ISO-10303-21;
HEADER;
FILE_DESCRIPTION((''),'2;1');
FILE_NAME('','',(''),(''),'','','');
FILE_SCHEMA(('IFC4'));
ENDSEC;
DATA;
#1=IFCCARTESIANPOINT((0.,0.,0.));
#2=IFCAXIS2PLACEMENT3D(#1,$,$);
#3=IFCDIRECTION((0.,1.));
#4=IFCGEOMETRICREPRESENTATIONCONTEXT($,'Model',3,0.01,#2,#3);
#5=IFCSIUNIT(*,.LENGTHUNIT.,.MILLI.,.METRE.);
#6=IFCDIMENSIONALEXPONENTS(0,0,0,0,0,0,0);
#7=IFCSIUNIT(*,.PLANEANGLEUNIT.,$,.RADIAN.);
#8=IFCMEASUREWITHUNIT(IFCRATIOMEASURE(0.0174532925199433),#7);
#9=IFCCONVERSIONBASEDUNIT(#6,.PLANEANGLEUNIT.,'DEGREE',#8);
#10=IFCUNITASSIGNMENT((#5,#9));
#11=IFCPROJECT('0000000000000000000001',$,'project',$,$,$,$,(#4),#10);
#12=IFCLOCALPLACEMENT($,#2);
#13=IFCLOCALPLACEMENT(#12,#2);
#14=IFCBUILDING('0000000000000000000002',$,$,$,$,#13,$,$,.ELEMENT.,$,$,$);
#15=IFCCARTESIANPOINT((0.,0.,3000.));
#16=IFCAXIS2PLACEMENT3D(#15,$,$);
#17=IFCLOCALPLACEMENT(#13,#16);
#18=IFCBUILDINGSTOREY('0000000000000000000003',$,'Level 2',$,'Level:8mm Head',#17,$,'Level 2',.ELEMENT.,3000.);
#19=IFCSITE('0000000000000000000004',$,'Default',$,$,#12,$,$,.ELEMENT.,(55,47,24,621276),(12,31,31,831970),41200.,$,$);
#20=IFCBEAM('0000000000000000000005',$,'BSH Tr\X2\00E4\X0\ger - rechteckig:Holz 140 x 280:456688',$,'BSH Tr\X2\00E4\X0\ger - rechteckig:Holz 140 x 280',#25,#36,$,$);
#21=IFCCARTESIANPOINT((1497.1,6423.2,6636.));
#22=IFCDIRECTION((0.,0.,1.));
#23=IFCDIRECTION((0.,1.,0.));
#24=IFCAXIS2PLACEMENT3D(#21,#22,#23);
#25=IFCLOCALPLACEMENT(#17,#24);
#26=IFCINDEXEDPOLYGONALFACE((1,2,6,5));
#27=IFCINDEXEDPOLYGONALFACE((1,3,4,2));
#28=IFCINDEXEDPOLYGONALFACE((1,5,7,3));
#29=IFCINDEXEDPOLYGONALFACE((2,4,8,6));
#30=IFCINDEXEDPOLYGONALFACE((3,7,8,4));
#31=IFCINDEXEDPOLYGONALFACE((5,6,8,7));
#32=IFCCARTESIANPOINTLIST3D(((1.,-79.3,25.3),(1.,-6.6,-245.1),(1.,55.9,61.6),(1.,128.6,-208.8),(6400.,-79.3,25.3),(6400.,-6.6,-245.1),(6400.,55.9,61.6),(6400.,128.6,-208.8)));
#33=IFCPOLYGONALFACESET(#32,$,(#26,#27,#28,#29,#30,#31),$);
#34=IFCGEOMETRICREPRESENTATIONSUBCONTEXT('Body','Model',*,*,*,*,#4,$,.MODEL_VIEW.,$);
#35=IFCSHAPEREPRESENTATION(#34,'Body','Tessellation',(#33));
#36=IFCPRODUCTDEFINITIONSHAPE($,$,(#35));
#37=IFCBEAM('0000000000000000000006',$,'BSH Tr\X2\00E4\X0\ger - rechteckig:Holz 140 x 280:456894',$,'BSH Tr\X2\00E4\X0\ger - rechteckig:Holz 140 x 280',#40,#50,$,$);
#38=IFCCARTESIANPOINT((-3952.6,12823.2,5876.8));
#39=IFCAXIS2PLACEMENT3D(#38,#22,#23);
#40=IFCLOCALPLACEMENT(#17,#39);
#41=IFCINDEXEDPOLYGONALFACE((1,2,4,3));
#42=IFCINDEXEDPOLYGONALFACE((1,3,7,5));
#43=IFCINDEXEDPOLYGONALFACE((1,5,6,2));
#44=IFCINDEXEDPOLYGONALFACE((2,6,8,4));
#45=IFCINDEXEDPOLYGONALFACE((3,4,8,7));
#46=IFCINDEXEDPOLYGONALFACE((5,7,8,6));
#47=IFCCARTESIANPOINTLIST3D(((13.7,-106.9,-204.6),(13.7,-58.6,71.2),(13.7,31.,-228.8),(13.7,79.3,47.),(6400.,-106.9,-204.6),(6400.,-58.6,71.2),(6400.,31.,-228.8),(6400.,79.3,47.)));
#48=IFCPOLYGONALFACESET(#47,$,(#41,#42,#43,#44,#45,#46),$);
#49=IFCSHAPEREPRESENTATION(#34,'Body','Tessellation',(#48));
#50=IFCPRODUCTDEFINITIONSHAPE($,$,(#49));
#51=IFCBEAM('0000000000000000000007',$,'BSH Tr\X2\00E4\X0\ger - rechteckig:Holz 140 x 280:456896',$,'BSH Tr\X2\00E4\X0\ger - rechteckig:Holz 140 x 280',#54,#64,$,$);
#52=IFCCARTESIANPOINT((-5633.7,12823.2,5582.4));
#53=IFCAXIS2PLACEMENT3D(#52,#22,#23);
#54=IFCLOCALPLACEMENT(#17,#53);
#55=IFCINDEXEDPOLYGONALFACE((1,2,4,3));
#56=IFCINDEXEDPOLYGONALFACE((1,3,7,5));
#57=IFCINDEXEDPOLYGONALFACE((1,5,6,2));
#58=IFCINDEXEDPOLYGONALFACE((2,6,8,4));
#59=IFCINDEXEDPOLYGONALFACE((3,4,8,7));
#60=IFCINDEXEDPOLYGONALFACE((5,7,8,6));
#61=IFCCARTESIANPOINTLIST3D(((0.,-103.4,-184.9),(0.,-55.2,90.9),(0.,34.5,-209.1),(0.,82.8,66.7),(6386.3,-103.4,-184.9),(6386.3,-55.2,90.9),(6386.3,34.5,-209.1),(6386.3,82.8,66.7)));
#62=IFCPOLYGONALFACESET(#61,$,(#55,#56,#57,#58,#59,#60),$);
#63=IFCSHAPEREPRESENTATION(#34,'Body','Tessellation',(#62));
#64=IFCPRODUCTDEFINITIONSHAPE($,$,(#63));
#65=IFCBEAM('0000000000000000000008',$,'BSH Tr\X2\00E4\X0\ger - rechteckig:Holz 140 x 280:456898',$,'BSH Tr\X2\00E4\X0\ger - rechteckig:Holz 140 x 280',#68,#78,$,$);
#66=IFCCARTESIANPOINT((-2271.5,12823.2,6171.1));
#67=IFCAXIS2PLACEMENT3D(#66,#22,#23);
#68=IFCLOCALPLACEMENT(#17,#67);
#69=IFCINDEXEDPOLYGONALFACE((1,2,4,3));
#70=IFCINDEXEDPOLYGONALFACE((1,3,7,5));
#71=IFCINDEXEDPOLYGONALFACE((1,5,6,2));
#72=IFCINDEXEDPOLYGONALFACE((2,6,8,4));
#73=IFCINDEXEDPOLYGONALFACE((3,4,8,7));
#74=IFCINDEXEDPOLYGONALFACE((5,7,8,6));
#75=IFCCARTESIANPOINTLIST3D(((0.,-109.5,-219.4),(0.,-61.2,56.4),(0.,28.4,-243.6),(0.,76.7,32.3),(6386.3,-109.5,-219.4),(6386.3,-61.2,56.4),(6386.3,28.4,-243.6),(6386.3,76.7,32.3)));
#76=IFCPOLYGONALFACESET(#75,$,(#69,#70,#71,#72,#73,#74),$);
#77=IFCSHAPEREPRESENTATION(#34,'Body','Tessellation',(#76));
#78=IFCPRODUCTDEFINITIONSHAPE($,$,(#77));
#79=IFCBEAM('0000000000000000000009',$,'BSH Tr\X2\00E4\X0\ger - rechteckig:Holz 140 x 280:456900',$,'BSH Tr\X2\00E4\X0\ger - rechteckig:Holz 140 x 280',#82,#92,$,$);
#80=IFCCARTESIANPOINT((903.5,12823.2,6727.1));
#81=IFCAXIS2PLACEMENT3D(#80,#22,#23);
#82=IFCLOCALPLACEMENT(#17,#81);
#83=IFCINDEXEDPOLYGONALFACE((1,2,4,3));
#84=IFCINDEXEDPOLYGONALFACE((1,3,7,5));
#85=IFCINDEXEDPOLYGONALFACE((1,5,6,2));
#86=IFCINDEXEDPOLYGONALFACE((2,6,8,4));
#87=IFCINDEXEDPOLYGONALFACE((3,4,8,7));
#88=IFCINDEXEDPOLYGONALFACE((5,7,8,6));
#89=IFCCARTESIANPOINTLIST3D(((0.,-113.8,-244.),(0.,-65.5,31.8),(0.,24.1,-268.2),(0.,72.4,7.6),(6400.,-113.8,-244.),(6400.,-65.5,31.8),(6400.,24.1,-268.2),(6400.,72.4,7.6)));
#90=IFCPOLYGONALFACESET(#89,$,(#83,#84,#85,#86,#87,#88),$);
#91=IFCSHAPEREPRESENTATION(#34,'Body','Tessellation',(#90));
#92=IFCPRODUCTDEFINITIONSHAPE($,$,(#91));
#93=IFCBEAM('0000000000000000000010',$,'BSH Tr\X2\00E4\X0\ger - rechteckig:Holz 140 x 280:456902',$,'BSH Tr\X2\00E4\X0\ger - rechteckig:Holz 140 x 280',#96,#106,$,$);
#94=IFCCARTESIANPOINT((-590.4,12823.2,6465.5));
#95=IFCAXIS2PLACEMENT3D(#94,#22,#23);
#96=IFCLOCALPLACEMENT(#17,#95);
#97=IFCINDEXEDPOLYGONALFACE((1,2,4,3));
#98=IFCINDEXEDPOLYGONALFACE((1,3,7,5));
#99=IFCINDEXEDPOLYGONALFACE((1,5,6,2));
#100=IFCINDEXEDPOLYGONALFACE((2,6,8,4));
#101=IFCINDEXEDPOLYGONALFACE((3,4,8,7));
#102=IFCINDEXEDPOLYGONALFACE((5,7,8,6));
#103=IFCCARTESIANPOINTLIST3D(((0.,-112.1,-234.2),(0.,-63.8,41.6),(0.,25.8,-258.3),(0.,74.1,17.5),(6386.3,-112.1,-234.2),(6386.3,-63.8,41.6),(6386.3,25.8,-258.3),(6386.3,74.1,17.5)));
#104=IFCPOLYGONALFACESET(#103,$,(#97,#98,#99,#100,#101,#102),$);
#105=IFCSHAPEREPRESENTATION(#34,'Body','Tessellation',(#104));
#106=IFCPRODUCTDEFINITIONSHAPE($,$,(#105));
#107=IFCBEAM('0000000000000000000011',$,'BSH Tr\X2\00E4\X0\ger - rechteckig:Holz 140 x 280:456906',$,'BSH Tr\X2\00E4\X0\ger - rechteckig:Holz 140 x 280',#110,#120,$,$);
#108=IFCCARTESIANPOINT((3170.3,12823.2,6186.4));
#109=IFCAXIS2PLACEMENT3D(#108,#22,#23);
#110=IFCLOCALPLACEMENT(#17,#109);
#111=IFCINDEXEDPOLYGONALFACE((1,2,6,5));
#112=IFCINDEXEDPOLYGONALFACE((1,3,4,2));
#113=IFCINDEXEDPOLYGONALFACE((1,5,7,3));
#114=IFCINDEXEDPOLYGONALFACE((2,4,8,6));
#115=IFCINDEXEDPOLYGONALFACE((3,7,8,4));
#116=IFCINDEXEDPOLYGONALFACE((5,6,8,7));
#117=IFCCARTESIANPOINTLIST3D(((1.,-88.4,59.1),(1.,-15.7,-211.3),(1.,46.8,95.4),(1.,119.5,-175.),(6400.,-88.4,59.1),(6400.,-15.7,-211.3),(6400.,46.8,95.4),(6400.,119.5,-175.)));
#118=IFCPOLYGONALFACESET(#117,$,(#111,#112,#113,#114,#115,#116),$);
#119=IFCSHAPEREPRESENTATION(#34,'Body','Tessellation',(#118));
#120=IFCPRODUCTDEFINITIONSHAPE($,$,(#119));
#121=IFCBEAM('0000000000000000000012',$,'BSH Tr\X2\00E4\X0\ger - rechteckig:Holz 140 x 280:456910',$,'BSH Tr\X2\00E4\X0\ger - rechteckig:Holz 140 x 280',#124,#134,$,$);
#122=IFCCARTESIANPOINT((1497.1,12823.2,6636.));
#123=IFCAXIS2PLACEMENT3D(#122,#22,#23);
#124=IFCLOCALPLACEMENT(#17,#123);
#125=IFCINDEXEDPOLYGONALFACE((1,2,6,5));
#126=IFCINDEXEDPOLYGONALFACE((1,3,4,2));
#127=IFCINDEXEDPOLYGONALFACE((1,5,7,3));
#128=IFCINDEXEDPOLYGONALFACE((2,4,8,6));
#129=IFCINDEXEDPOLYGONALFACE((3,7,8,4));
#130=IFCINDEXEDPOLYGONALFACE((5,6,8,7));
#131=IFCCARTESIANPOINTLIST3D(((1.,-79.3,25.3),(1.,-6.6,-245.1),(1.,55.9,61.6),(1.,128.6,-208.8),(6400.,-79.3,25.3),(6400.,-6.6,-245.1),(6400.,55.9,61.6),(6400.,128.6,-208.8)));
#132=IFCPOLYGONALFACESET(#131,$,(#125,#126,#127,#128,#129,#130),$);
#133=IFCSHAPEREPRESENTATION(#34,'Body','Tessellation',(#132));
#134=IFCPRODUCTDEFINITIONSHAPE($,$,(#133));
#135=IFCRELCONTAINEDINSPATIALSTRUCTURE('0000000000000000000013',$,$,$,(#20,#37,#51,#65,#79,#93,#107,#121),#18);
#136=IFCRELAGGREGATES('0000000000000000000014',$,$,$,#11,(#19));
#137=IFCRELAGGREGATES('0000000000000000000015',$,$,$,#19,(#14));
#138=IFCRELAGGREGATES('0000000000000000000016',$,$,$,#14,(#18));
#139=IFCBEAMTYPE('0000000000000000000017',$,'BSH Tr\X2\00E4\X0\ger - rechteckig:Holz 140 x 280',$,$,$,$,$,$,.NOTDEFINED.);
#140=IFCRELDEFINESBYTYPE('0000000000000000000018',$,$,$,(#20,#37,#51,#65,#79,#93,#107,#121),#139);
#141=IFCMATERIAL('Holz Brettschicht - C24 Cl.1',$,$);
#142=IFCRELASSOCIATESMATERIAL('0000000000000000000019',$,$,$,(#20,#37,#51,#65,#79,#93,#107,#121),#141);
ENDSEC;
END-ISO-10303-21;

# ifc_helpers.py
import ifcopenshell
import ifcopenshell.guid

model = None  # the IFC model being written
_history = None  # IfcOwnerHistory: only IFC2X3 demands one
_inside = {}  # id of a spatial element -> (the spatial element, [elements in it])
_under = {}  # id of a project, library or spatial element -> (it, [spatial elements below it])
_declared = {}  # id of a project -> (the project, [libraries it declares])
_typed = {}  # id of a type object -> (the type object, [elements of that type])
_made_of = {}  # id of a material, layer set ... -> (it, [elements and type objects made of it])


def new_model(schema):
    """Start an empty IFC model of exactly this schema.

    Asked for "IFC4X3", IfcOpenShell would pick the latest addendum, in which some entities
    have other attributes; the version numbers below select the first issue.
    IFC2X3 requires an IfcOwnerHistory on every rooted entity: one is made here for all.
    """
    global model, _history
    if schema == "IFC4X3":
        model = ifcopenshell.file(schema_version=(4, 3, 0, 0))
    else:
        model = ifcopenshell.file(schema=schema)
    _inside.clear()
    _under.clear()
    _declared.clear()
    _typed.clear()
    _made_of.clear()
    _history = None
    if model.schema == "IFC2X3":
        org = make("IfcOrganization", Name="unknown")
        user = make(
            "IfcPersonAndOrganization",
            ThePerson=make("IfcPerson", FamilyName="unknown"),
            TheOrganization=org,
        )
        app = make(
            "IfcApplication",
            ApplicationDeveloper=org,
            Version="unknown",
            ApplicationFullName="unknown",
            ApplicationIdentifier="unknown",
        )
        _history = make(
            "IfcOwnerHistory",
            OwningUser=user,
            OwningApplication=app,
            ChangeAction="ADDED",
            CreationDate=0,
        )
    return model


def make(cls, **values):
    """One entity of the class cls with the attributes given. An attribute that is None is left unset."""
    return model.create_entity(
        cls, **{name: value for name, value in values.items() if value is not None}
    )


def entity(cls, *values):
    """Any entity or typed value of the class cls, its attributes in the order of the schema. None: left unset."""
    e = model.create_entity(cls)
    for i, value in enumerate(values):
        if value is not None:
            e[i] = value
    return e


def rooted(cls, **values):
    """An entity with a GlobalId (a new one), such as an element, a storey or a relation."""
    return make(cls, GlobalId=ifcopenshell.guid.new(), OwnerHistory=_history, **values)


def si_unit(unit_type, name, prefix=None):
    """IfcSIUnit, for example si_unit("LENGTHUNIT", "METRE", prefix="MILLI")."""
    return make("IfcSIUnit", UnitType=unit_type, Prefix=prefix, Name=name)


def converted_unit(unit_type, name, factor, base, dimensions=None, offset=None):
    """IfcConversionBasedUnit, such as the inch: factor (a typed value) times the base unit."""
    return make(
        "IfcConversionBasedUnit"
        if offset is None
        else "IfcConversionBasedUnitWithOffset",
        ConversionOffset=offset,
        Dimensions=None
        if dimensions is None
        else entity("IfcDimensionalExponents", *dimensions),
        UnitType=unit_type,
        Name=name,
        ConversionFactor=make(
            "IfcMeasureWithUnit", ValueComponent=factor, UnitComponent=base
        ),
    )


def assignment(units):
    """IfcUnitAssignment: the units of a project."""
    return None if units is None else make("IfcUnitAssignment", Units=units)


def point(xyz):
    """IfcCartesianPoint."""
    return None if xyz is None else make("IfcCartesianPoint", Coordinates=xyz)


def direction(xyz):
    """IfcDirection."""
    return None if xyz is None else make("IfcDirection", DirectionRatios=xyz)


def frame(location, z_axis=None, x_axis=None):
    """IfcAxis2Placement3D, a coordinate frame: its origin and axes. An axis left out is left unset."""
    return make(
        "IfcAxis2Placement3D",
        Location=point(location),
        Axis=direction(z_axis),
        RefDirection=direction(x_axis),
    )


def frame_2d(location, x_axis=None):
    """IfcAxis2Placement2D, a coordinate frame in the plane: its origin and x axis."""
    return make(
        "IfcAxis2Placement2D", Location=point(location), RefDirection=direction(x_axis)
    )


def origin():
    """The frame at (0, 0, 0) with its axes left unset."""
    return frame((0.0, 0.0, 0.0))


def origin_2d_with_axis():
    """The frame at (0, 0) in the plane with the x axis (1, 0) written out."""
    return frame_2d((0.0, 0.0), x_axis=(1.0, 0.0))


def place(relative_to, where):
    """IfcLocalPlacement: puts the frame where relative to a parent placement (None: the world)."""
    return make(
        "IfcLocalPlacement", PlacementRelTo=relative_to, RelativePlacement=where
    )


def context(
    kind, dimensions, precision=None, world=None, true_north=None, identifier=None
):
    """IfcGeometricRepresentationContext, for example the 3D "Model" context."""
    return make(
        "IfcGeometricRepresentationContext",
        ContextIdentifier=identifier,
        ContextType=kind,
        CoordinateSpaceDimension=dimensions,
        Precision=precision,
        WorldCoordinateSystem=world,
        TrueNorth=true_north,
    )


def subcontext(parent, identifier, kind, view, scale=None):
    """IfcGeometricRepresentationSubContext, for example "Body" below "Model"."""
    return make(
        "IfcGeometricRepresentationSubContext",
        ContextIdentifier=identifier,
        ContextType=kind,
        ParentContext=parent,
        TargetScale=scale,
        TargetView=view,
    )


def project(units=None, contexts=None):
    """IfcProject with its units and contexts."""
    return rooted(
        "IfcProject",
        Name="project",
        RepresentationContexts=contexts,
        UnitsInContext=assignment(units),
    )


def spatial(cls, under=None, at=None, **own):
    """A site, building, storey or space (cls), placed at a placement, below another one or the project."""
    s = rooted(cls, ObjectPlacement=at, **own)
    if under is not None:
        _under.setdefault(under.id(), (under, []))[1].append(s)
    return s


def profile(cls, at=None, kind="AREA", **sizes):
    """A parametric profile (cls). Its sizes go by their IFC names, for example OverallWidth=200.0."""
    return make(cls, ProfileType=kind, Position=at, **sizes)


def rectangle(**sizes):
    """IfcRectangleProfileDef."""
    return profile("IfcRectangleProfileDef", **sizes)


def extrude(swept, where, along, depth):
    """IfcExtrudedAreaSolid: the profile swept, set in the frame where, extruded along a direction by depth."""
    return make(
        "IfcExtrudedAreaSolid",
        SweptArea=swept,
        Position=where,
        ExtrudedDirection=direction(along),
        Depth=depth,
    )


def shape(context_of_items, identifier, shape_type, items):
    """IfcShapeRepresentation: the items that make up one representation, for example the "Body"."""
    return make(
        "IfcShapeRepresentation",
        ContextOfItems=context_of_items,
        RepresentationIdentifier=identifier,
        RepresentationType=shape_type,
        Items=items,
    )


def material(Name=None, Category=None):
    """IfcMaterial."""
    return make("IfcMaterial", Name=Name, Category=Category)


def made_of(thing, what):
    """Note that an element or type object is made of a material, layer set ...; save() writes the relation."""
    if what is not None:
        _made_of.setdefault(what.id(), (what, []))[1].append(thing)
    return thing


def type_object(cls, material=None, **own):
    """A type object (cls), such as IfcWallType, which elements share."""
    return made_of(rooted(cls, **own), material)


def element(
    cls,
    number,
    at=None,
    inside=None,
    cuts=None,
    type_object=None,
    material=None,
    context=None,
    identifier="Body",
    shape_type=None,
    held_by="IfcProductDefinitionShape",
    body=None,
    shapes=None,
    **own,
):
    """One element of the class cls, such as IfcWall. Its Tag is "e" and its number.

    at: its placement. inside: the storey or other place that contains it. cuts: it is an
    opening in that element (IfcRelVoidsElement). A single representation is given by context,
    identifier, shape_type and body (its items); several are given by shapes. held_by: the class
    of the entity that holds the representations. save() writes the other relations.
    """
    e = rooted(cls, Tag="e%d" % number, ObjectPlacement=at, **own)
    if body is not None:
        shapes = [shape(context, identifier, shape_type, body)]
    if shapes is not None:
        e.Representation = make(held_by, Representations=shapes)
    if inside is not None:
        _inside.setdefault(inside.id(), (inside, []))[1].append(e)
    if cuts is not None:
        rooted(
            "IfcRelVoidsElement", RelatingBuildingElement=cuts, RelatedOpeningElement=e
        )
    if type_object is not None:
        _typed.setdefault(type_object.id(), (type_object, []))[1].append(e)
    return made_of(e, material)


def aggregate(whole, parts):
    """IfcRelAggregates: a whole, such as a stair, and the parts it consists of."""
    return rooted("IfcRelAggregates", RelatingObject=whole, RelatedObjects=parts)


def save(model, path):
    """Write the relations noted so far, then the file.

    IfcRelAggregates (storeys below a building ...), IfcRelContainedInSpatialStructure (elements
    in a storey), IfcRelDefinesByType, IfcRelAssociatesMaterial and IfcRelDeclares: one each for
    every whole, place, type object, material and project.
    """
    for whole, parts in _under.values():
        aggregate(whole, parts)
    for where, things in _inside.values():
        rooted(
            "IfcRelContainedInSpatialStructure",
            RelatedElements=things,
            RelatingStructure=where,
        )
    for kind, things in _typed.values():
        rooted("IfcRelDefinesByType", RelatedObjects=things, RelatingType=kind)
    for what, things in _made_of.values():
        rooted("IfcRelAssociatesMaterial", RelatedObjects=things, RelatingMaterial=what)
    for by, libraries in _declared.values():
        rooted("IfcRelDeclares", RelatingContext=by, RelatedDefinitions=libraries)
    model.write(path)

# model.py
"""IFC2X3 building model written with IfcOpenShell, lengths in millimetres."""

from ifc_helpers import new_model, entity, si_unit, converted_unit, direction, frame, frame_2d, origin, origin_2d_with_axis, place, context, subcontext, project, spatial, rectangle, extrude, material, type_object, element, save


model = new_model("IFC2X3")

# Units and contexts
model_context = context("Model", 3, precision=0.01, world=origin(), true_north=direction((0.0, 1.0)))
body_context = subcontext(model_context, "Body", "Model", "MODEL_VIEW")
ifc_project = project(units=[si_unit("LENGTHUNIT", "METRE", prefix="MILLI"), converted_unit("PLANEANGLEUNIT", "DEGREE", entity("IfcRatioMeasure", 0.0174532925199433), si_unit("PLANEANGLEUNIT", "RADIAN"), dimensions=[0, 0, 0, 0, 0, 0, 0])], contexts=[model_context])

# Site, building, storey
site_placement = place(None, origin())
site = spatial("IfcSite", under=ifc_project, at=site_placement, Name="Default", CompositionType="ELEMENT", RefLatitude=(55, 47, 24, 621276), RefLongitude=(12, 31, 31, 831970), RefElevation=41200.0)
building_placement = place(site_placement, origin())
building = spatial("IfcBuilding", under=site, at=building_placement, CompositionType="ELEMENT")
storey_placement = place(building_placement, frame((0.0, 0.0, 3000.0)))
storey = spatial("IfcBuildingStorey", under=building, at=storey_placement, Name="Level 2", ObjectType="Level:8mm Head", LongName="Level 2", CompositionType="ELEMENT", Elevation=3000.0)

# Shared definitions
ifc_material_1 = material(Name="Holz Brettschicht - C24 Cl.1")

# Beams
beam_type_1 = type_object("IfcBeamType", Name="BSH Träger - rechteckig:Holz 140 x 280", PredefinedType="NOTDEFINED")
beam_1_placement = place(storey_placement, frame((1497.1, 6423.2, 6636.0), z_axis=(0.0, 0.0, 1.0), x_axis=(0.0, 1.0, 0.0)))
element("IfcBeam", 1, at=beam_1_placement, inside=storey, type_object=beam_type_1, material=ifc_material_1, Name="BSH Träger - rechteckig:Holz 140 x 280:456688", ObjectType="BSH Träger - rechteckig:Holz 140 x 280", context=body_context, shape_type="SweptSolid", body=[
    extrude(rectangle(XDim=280.0, YDim=140.0, at=frame_2d((0.0, 0.0), x_axis=(1.0, 0.0))), frame((1.0, 24.7, -91.7), z_axis=(1.0, 0.0, 0.0), x_axis=(0.0, -0.259528, 0.965735)), (0.0, 0.0, 1.0), 6399.0),
])
beam_2_placement = place(storey_placement, frame((-3952.6, 12823.2, 5876.8), z_axis=(0.0, 0.0, 1.0), x_axis=(0.0, 1.0, 0.0)))
element("IfcBeam", 2, at=beam_2_placement, inside=storey, type_object=beam_type_1, material=ifc_material_1, Name="BSH Träger - rechteckig:Holz 140 x 280:456894", ObjectType="BSH Träger - rechteckig:Holz 140 x 280", context=body_context, shape_type="SweptSolid", body=[
    extrude(rectangle(XDim=280.0, YDim=140.0, at=origin_2d_with_axis()), frame((13.7, -13.8, -78.8), z_axis=(1.0, 0.0, 0.0), x_axis=(0.0, 0.172491, 0.985011)), (0.0, 0.0, 1.0), 6386.3),
])
beam_3_placement = place(storey_placement, frame((-5633.7, 12823.2, 5582.4), z_axis=(0.0, 0.0, 1.0), x_axis=(0.0, 1.0, 0.0)))
element("IfcBeam", 3, at=beam_3_placement, inside=storey, type_object=beam_type_1, material=ifc_material_1, Name="BSH Träger - rechteckig:Holz 140 x 280:456896", ObjectType="BSH Träger - rechteckig:Holz 140 x 280", context=body_context, shape_type="SweptSolid", body=[
    extrude(rectangle(XDim=280.0, YDim=140.0, at=origin_2d_with_axis()), frame((0.0, -10.3, -59.1), z_axis=(1.0, 0.0, 0.0), x_axis=(0.0, 0.172491, 0.985011)), (0.0, 0.0, 1.0), 6386.3),
])
beam_4_placement = place(storey_placement, frame((-2271.5, 12823.2, 6171.1), z_axis=(0.0, 0.0, 1.0), x_axis=(0.0, 1.0, 0.0)))
element("IfcBeam", 4, at=beam_4_placement, inside=storey, type_object=beam_type_1, material=ifc_material_1, Name="BSH Träger - rechteckig:Holz 140 x 280:456898", ObjectType="BSH Träger - rechteckig:Holz 140 x 280", context=body_context, shape_type="SweptSolid", body=[
    extrude(rectangle(XDim=280.0, YDim=140.0, at=frame_2d((0.0, 0.0), x_axis=(1.0, 0.0))), frame((0.0, -16.4, -93.6), z_axis=(1.0, 0.0, 0.0), x_axis=(0.0, 0.172491, 0.985011)), (0.0, 0.0, 1.0), 6386.3),
])
beam_5_placement = place(storey_placement, frame((903.5, 12823.2, 6727.1), z_axis=(0.0, 0.0, 1.0), x_axis=(0.0, 1.0, 0.0)))
element("IfcBeam", 5, at=beam_5_placement, inside=storey, type_object=beam_type_1, material=ifc_material_1, Name="BSH Träger - rechteckig:Holz 140 x 280:456900", ObjectType="BSH Träger - rechteckig:Holz 140 x 280", context=body_context, shape_type="SweptSolid", body=[
    extrude(rectangle(XDim=280.0, YDim=140.0, at=frame_2d((0.0, 0.0), x_axis=(1.0, 0.0))), frame((0.0, -20.7, -118.2), z_axis=(1.0, 0.0, 0.0), x_axis=(0.0, 0.172491, 0.985011)), (0.0, 0.0, 1.0), 6400.0),
])
beam_6_placement = place(storey_placement, frame((-590.4, 12823.2, 6465.5), z_axis=(0.0, 0.0, 1.0), x_axis=(0.0, 1.0, 0.0)))
element("IfcBeam", 6, at=beam_6_placement, inside=storey, type_object=beam_type_1, material=ifc_material_1, Name="BSH Träger - rechteckig:Holz 140 x 280:456902", ObjectType="BSH Träger - rechteckig:Holz 140 x 280", context=body_context, shape_type="SweptSolid", body=[
    extrude(rectangle(XDim=280.0, YDim=140.0, at=frame_2d((0.0, 0.0), x_axis=(1.0, 0.0))), frame((0.0, -19.0, -108.4), z_axis=(1.0, 0.0, 0.0), x_axis=(0.0, 0.172491, 0.985011)), (0.0, 0.0, 1.0), 6386.3),
])
beam_7_placement = place(storey_placement, frame((3170.3, 12823.2, 6186.4), z_axis=(0.0, 0.0, 1.0), x_axis=(0.0, 1.0, 0.0)))
element("IfcBeam", 7, at=beam_7_placement, inside=storey, type_object=beam_type_1, material=ifc_material_1, Name="BSH Träger - rechteckig:Holz 140 x 280:456906", ObjectType="BSH Träger - rechteckig:Holz 140 x 280", context=body_context, shape_type="SweptSolid", body=[
    extrude(rectangle(XDim=280.0, YDim=140.0, at=frame_2d((0.0, 0.0), x_axis=(1.0, 0.0))), frame((1.0, 15.6, -57.9), z_axis=(1.0, 0.0, 0.0), x_axis=(0.0, -0.259528, 0.965735)), (0.0, 0.0, 1.0), 6399.0),
])
beam_8_placement = place(storey_placement, frame((1497.1, 12823.2, 6636.0), z_axis=(0.0, 0.0, 1.0), x_axis=(0.0, 1.0, 0.0)))
element("IfcBeam", 8, at=beam_8_placement, inside=storey, type_object=beam_type_1, material=ifc_material_1, Name="BSH Träger - rechteckig:Holz 140 x 280:456910", ObjectType="BSH Träger - rechteckig:Holz 140 x 280", context=body_context, shape_type="SweptSolid", body=[
    extrude(rectangle(XDim=280.0, YDim=140.0, at=frame_2d((0.0, 0.0), x_axis=(1.0, 0.0))), frame((1.0, 24.7, -91.7), z_axis=(1.0, 0.0, 0.0), x_axis=(0.0, -0.259528, 0.965735)), (0.0, 0.0, 1.0), 6399.0),
])

save(model, "model.ifc")
